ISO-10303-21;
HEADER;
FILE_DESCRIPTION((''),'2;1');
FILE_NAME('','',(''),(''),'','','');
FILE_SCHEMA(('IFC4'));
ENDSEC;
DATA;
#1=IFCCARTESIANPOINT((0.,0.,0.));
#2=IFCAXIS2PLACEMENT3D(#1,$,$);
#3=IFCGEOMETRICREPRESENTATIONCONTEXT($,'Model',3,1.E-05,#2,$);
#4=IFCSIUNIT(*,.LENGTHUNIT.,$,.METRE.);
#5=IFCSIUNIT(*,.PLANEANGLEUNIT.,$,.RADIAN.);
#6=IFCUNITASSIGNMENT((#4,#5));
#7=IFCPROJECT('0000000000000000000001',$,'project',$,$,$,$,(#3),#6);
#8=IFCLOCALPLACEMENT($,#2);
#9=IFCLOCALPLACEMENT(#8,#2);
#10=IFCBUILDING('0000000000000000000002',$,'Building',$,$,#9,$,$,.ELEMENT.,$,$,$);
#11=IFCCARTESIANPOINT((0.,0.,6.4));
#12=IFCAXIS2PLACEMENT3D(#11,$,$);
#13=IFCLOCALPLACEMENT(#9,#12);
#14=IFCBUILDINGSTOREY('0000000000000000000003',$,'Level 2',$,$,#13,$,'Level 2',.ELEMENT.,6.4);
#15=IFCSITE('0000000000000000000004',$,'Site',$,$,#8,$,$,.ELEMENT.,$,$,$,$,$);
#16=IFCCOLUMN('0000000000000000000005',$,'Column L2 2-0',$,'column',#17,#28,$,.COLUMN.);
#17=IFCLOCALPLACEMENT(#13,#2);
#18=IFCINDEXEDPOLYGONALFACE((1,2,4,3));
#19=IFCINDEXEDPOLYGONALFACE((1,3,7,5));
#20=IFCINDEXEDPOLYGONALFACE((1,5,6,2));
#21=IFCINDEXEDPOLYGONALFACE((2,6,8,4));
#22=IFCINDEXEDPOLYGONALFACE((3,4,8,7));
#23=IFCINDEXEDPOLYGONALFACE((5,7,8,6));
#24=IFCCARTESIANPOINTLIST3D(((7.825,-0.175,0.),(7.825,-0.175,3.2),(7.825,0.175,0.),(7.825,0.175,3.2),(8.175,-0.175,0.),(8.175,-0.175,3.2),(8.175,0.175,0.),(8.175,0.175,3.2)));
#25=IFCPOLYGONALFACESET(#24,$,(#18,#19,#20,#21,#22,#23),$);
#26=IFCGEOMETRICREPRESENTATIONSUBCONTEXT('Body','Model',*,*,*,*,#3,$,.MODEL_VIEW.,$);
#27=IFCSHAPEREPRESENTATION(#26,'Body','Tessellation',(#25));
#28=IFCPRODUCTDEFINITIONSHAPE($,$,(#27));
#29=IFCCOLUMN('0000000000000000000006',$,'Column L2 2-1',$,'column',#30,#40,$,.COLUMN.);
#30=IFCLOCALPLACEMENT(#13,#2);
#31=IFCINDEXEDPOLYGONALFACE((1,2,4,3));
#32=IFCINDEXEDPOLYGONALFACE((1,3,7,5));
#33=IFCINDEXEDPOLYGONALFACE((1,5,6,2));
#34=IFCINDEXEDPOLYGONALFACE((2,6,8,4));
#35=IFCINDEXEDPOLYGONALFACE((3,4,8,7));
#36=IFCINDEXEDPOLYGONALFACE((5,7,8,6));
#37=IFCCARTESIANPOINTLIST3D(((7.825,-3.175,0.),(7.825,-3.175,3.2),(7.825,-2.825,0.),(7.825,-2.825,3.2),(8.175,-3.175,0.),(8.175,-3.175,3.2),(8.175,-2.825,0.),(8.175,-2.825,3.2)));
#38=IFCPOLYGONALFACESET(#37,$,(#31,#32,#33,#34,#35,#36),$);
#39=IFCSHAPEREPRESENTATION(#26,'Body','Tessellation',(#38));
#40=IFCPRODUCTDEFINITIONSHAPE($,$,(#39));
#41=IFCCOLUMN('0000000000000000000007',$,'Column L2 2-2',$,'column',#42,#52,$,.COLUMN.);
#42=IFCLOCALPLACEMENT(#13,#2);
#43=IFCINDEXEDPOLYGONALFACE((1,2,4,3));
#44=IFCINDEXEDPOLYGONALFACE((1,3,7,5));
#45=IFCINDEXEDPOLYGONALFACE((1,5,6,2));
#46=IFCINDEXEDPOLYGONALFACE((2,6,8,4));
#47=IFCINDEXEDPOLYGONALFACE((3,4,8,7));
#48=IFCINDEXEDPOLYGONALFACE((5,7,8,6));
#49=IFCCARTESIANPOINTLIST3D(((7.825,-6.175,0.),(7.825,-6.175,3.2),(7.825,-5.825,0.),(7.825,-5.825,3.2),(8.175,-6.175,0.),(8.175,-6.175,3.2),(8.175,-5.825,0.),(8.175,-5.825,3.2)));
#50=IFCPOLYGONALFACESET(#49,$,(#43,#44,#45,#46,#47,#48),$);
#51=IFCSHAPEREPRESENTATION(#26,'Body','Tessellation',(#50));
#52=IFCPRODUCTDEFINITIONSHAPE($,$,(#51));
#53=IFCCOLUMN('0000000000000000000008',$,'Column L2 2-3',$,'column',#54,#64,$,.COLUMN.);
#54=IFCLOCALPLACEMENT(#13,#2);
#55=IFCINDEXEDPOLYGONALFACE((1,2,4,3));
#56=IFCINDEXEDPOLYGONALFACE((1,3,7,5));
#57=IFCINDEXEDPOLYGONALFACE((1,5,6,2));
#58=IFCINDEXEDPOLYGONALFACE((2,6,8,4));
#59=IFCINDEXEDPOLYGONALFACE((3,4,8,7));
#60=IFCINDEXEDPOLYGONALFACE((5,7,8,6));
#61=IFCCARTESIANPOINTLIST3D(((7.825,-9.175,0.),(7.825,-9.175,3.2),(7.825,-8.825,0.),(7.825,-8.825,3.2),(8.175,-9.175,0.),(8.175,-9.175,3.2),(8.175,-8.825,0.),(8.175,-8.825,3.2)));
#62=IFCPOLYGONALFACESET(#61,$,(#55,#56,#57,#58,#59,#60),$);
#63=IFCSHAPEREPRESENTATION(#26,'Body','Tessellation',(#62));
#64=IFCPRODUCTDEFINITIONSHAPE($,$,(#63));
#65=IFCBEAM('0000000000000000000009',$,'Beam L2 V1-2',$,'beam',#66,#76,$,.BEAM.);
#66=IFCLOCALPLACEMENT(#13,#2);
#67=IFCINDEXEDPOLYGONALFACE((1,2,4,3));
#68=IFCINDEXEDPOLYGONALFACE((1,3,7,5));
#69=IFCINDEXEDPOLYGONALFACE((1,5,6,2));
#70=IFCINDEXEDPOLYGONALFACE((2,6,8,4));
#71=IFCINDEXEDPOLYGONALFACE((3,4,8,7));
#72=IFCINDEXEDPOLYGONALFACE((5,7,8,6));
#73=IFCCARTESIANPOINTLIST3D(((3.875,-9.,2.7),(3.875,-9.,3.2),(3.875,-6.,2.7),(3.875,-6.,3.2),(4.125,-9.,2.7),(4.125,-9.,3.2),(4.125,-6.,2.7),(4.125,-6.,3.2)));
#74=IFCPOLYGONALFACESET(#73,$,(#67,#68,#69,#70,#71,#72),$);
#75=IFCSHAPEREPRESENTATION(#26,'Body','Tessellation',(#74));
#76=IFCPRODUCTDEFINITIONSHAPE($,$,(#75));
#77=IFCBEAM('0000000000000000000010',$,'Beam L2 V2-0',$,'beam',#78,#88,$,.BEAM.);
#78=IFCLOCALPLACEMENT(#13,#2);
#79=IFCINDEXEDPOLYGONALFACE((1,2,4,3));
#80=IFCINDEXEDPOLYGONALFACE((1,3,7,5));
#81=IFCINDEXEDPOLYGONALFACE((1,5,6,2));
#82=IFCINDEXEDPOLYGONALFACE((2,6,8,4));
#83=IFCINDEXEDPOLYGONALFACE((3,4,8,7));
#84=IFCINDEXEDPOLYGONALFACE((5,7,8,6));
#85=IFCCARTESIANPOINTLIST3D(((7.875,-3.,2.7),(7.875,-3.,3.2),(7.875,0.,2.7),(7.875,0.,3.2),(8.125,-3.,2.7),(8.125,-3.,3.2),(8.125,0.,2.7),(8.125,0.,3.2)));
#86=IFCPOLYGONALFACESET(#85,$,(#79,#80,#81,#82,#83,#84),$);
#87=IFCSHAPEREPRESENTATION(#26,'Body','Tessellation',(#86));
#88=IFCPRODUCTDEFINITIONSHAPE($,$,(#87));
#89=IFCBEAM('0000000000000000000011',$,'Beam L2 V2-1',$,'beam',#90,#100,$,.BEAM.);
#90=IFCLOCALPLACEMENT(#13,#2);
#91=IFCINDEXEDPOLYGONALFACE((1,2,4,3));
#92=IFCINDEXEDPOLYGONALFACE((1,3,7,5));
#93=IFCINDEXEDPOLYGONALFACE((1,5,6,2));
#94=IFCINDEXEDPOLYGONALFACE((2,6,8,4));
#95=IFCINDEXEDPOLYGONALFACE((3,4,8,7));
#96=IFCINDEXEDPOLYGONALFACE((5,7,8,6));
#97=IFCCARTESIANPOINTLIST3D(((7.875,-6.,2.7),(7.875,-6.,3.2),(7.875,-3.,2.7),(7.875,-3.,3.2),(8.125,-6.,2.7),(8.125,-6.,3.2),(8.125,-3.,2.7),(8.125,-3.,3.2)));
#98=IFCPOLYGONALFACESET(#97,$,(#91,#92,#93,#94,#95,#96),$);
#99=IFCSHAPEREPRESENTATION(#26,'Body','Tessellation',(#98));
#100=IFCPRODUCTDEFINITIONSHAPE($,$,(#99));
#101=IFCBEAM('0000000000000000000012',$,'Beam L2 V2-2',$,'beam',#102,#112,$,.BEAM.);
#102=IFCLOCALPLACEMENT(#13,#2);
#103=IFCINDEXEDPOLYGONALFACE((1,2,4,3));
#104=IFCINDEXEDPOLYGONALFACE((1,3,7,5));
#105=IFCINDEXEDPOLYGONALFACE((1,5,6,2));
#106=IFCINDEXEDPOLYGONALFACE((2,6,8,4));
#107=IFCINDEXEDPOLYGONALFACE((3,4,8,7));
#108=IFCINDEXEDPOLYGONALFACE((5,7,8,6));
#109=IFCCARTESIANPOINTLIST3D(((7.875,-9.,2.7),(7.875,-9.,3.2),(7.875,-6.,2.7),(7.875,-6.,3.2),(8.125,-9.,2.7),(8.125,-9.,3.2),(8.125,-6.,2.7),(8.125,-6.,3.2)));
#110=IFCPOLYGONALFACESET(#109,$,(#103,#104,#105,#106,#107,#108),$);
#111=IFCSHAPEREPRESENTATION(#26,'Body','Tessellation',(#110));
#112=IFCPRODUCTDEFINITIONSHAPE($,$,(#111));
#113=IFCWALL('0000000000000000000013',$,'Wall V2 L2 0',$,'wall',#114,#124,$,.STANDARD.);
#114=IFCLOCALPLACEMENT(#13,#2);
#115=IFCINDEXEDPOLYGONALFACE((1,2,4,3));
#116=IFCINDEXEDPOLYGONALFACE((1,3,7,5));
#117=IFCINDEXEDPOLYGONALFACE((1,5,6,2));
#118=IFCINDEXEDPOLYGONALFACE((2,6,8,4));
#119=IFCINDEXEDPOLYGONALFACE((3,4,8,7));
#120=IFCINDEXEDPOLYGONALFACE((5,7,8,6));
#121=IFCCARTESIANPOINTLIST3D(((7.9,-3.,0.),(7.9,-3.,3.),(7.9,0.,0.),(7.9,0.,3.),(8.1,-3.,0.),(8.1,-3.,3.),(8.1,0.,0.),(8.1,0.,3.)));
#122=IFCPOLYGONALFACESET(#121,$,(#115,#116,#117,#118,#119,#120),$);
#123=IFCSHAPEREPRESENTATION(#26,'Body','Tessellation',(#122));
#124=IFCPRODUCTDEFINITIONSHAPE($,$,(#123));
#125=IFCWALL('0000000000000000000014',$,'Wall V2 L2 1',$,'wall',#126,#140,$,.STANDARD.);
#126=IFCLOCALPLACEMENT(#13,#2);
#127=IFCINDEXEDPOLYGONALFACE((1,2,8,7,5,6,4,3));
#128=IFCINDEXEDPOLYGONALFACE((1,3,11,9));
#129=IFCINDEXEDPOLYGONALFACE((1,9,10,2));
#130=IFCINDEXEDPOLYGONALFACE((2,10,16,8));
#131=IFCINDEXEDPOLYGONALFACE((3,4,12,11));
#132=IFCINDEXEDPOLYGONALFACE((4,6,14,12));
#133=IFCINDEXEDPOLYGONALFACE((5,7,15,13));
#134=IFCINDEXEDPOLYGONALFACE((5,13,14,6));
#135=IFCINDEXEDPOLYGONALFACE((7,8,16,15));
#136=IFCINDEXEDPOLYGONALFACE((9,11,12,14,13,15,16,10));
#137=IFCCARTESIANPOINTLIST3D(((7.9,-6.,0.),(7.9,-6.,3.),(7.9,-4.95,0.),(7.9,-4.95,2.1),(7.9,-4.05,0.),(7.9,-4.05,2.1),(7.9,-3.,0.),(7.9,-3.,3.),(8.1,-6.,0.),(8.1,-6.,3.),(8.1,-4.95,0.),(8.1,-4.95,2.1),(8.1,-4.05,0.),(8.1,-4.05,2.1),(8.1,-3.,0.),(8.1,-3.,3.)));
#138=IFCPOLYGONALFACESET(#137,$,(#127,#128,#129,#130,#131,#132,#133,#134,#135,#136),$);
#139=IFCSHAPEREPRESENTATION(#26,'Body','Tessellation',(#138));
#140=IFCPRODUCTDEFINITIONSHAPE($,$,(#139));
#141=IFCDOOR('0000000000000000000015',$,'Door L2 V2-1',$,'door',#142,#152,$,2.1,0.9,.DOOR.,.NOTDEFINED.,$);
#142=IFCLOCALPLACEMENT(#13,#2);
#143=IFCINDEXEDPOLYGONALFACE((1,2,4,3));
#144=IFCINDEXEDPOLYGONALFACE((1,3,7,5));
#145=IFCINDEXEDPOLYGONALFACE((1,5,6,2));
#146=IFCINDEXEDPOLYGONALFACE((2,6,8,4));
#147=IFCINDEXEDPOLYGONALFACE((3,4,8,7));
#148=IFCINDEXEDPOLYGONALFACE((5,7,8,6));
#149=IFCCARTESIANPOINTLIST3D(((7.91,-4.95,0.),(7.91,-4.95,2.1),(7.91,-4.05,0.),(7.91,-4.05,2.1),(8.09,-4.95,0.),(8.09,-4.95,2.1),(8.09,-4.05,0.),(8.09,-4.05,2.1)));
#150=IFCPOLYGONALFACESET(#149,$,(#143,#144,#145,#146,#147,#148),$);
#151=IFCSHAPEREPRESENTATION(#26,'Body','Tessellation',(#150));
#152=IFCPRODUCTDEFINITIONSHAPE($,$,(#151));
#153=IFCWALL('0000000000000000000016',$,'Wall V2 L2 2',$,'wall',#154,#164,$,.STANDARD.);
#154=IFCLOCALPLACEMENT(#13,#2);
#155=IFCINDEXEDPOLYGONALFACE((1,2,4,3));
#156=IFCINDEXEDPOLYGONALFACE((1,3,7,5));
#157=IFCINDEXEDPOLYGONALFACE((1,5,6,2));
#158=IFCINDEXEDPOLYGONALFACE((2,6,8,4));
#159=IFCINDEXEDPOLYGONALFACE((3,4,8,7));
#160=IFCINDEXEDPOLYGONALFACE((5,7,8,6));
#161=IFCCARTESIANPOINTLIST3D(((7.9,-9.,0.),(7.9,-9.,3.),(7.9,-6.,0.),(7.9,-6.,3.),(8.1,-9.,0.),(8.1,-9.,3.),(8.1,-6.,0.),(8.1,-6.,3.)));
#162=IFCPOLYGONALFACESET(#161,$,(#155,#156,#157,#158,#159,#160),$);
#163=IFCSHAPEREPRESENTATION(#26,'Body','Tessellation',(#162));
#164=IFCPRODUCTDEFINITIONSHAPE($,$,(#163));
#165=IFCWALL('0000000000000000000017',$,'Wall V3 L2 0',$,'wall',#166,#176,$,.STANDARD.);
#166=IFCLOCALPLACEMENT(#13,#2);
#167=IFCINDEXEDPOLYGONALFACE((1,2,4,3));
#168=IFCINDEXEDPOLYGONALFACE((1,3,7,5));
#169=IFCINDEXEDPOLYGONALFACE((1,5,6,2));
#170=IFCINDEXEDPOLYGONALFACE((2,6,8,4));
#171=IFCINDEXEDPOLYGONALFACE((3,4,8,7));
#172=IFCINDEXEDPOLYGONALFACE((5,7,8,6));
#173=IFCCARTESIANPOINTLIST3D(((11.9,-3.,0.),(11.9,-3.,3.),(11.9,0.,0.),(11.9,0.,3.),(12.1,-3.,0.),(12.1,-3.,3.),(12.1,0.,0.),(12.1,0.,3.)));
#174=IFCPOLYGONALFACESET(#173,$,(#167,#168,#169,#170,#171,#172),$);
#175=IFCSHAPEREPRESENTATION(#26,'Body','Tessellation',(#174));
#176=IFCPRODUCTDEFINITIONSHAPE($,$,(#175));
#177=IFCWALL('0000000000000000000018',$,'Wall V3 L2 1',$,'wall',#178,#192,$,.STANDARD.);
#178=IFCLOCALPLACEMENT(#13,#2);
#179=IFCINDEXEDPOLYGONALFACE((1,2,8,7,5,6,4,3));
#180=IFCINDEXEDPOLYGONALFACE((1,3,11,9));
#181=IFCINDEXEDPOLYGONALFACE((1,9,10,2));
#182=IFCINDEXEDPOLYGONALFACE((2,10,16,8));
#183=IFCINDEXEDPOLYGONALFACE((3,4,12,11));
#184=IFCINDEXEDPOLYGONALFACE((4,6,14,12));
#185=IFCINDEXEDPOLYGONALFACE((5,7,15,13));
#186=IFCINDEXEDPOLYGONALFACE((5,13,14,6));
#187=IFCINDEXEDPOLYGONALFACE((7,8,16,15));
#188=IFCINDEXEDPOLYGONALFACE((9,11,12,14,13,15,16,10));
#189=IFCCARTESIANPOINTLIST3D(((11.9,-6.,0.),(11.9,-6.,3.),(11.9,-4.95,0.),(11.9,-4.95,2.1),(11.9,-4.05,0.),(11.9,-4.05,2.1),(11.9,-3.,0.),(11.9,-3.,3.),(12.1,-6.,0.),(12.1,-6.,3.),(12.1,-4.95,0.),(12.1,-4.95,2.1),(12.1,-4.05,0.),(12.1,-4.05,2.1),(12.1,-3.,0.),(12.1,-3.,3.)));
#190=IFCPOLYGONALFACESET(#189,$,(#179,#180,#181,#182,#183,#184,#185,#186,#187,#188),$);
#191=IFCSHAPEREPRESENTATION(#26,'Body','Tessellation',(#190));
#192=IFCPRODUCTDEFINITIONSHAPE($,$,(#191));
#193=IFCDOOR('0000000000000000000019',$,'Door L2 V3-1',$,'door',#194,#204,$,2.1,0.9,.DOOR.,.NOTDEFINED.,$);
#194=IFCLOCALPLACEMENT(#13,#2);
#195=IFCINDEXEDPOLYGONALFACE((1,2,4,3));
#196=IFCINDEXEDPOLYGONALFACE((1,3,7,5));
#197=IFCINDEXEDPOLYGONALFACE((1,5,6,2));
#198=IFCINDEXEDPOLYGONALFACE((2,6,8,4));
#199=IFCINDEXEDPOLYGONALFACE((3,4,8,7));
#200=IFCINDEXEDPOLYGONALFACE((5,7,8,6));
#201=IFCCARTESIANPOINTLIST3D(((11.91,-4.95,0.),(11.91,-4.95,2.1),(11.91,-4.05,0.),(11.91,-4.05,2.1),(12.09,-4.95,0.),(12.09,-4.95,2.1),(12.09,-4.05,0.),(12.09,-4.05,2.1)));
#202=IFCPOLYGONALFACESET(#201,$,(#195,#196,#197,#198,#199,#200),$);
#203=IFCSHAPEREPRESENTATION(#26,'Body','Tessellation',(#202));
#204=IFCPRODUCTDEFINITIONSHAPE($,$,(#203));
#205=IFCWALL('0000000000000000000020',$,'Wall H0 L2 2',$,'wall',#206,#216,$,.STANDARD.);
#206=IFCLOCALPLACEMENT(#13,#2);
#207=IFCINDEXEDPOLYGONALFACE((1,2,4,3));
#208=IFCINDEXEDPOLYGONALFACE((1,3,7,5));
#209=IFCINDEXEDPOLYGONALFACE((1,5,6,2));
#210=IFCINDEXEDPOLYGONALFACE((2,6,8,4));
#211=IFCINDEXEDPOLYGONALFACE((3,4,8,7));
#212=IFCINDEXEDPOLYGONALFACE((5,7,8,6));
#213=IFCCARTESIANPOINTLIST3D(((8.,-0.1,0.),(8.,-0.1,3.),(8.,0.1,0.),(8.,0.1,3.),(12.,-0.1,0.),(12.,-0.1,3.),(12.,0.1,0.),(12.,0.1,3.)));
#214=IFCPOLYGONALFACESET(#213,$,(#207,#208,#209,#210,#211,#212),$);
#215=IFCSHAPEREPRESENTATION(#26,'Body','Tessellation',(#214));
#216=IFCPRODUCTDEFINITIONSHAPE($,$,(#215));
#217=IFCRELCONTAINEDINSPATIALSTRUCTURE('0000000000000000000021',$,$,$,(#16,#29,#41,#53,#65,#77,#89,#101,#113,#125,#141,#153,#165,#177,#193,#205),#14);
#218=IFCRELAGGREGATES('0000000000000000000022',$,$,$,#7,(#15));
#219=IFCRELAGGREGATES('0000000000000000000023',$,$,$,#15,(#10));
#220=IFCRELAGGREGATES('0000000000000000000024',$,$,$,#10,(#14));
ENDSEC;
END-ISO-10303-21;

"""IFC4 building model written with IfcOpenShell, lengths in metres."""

from ifc_helpers import new_model, si_unit, frame, frame_2d, origin, origin_2d, place, context, subcontext, project, spatial, rectangle, extrude, element, fill, save


model = new_model("IFC4")

# Units and contexts
model_context = context("Model", 3, precision=1e-05, world=origin())
body_context = subcontext(model_context, "Body", "Model", "MODEL_VIEW")
ifc_project = project(units=[si_unit("LENGTHUNIT", "METRE"), si_unit("PLANEANGLEUNIT", "RADIAN")], contexts=[model_context])

# Site, building, storey
site_placement = place(None, origin())
site = spatial("IfcSite", under=ifc_project, at=site_placement, Name="Site", CompositionType="ELEMENT")
building_placement = place(site_placement, origin())
building = spatial("IfcBuilding", under=site, at=building_placement, Name="Building", CompositionType="ELEMENT")
storey_placement = place(building_placement, frame((0.0, 0.0, 6.4)))
storey = spatial("IfcBuildingStorey", under=building, at=storey_placement, Name="Level 2", LongName="Level 2", CompositionType="ELEMENT", Elevation=6.4)

# Columns
for number, where, name in (
    (1, (8.0, 0.0, 0.0), "Column L2 2-0"),
    (2, (8.0, -3.0, 0.0), "Column L2 2-1"),
    (3, (8.0, -6.0, 0.0), "Column L2 2-2"),
    (4, (8.0, -9.0, 0.0), "Column L2 2-3"),
):
    element("IfcColumn", number, at=place(storey_placement, frame(where)), inside=storey, Name=name, ObjectType="column", PredefinedType="COLUMN", context=body_context, shape_type="SweptSolid", body=[
        extrude(rectangle(XDim=0.35, YDim=0.35, at=origin_2d()), origin(), (0.0, 0.0, 1.0), 3.2),
    ])

# Beams
for number, where, z_axis, x_axis, name in (
    (5, (4.0, -6.0, 2.95), (0.0, -1.0, 0.0), (0.0, 0.0, 1.0), "Beam L2 V1-2"),
    (6, (8.0, 0.0, 2.95), (0.0, -1.0, 0.0), (0.0, 0.0, 1.0), "Beam L2 V2-0"),
    (7, (8.0, -3.0, 2.95), (0.0, -1.0, 0.0), (0.0, 0.0, 1.0), "Beam L2 V2-1"),
    (8, (8.0, -6.0, 2.95), (0.0, -1.0, 0.0), (0.0, 0.0, 1.0), "Beam L2 V2-2"),
):
    element("IfcBeam", number, at=place(storey_placement, frame(where, z_axis=z_axis, x_axis=x_axis)), inside=storey, Name=name, ObjectType="beam", PredefinedType="BEAM", context=body_context, shape_type="SweptSolid", body=[
        extrude(rectangle(XDim=0.5, YDim=0.25, at=origin_2d()), origin(), (0.0, 0.0, 1.0), 3.0),
    ])

# Wall
wall_1_placement = place(storey_placement, frame((8.0, 0.0, 0.0), z_axis=(0.0, 0.0, 1.0), x_axis=(0.0, -1.0, 0.0)))
element("IfcWall", 9, at=wall_1_placement, inside=storey, Name="Wall V2 L2 0", ObjectType="wall", PredefinedType="STANDARD", context=body_context, shape_type="SweptSolid", body=[
    extrude(rectangle(XDim=3.0, YDim=0.2, at=frame_2d((1.5, 0.0))), origin(), (0.0, 0.0, 1.0), 3.0),
])

# Wall, opening, door
wall_2_placement = place(storey_placement, frame((8.0, -3.0, 0.0), z_axis=(0.0, 0.0, 1.0), x_axis=(0.0, -1.0, 0.0)))
wall_2 = element("IfcWall", 10, at=wall_2_placement, inside=storey, Name="Wall V2 L2 1", ObjectType="wall", PredefinedType="STANDARD", context=body_context, shape_type="SweptSolid", body=[
    extrude(rectangle(XDim=3.0, YDim=0.2, at=frame_2d((1.5, 0.0))), origin(), (0.0, 0.0, 1.0), 3.0),
])
opening_1_placement = place(storey_placement, frame((8.0, -4.5, 0.0), z_axis=(0.0, 0.0, 1.0), x_axis=(0.0, -1.0, 0.0)))
opening_1 = element("IfcOpeningElement", 11, at=opening_1_placement, cuts=wall_2, ObjectType="Opening", PredefinedType="OPENING", context=body_context, shape_type="SweptSolid", body=[
    extrude(rectangle(XDim=0.9, YDim=0.22, at=origin_2d()), origin(), (0.0, 0.0, 1.0), 2.1),
])
door_1_placement = place(storey_placement, frame((8.0, -4.5, 0.0), z_axis=(0.0, 0.0, 1.0), x_axis=(0.0, -1.0, 0.0)))
door_1 = element("IfcDoor", 12, at=door_1_placement, inside=storey, Name="Door L2 V2-1", ObjectType="door", OperationType="NOTDEFINED", OverallHeight=2.1, OverallWidth=0.9, PredefinedType="DOOR", context=body_context, shape_type="SweptSolid", body=[
    extrude(rectangle(XDim=0.9, YDim=0.18, at=origin_2d()), origin(), (0.0, 0.0, 1.0), 2.1),
])
fill(opening_1, door_1)

# Walls
for number, where, z_axis, x_axis, name in (
    (13, (8.0, -6.0, 0.0), (0.0, 0.0, 1.0), (0.0, -1.0, 0.0), "Wall V2 L2 2"),
    (14, (12.0, 0.0, 0.0), (0.0, 0.0, 1.0), (0.0, -1.0, 0.0), "Wall V3 L2 0"),
):
    element("IfcWall", number, at=place(storey_placement, frame(where, z_axis=z_axis, x_axis=x_axis)), inside=storey, Name=name, ObjectType="wall", PredefinedType="STANDARD", context=body_context, shape_type="SweptSolid", body=[
        extrude(rectangle(XDim=3.0, YDim=0.2, at=frame_2d((1.5, 0.0))), origin(), (0.0, 0.0, 1.0), 3.0),
    ])

# Wall, opening, door
wall_3_placement = place(storey_placement, frame((12.0, -3.0, 0.0), z_axis=(0.0, 0.0, 1.0), x_axis=(0.0, -1.0, 0.0)))
wall_3 = element("IfcWall", 15, at=wall_3_placement, inside=storey, Name="Wall V3 L2 1", ObjectType="wall", PredefinedType="STANDARD", context=body_context, shape_type="SweptSolid", body=[
    extrude(rectangle(XDim=3.0, YDim=0.2, at=frame_2d((1.5, 0.0))), origin(), (0.0, 0.0, 1.0), 3.0),
])
opening_2_placement = place(storey_placement, frame((12.0, -4.5, 0.0), z_axis=(0.0, 0.0, 1.0), x_axis=(0.0, -1.0, 0.0)))
opening_2 = element("IfcOpeningElement", 16, at=opening_2_placement, cuts=wall_3, ObjectType="Opening", PredefinedType="OPENING", context=body_context, shape_type="SweptSolid", body=[
    extrude(rectangle(XDim=0.9, YDim=0.22, at=origin_2d()), origin(), (0.0, 0.0, 1.0), 2.1),
])
door_2_placement = place(storey_placement, frame((12.0, -4.5, 0.0), z_axis=(0.0, 0.0, 1.0), x_axis=(0.0, -1.0, 0.0)))
door_2 = element("IfcDoor", 17, at=door_2_placement, inside=storey, Name="Door L2 V3-1", ObjectType="door", OperationType="NOTDEFINED", OverallHeight=2.1, OverallWidth=0.9, PredefinedType="DOOR", context=body_context, shape_type="SweptSolid", body=[
    extrude(rectangle(XDim=0.9, YDim=0.18, at=origin_2d()), origin(), (0.0, 0.0, 1.0), 2.1),
])
fill(opening_2, door_2)

# Wall
wall_4_placement = place(storey_placement, frame((8.0, 0.0, 0.0), z_axis=(0.0, 0.0, 1.0), x_axis=(1.0, 0.0, 0.0)))
element("IfcWall", 18, at=wall_4_placement, inside=storey, Name="Wall H0 L2 2", ObjectType="wall", PredefinedType="STANDARD", context=body_context, shape_type="SweptSolid", body=[
    extrude(rectangle(XDim=4.0, YDim=0.2, at=frame_2d((2.0, 0.0))), origin(), (0.0, 0.0, 1.0), 3.0),
])

save(model, "model.ifc")
